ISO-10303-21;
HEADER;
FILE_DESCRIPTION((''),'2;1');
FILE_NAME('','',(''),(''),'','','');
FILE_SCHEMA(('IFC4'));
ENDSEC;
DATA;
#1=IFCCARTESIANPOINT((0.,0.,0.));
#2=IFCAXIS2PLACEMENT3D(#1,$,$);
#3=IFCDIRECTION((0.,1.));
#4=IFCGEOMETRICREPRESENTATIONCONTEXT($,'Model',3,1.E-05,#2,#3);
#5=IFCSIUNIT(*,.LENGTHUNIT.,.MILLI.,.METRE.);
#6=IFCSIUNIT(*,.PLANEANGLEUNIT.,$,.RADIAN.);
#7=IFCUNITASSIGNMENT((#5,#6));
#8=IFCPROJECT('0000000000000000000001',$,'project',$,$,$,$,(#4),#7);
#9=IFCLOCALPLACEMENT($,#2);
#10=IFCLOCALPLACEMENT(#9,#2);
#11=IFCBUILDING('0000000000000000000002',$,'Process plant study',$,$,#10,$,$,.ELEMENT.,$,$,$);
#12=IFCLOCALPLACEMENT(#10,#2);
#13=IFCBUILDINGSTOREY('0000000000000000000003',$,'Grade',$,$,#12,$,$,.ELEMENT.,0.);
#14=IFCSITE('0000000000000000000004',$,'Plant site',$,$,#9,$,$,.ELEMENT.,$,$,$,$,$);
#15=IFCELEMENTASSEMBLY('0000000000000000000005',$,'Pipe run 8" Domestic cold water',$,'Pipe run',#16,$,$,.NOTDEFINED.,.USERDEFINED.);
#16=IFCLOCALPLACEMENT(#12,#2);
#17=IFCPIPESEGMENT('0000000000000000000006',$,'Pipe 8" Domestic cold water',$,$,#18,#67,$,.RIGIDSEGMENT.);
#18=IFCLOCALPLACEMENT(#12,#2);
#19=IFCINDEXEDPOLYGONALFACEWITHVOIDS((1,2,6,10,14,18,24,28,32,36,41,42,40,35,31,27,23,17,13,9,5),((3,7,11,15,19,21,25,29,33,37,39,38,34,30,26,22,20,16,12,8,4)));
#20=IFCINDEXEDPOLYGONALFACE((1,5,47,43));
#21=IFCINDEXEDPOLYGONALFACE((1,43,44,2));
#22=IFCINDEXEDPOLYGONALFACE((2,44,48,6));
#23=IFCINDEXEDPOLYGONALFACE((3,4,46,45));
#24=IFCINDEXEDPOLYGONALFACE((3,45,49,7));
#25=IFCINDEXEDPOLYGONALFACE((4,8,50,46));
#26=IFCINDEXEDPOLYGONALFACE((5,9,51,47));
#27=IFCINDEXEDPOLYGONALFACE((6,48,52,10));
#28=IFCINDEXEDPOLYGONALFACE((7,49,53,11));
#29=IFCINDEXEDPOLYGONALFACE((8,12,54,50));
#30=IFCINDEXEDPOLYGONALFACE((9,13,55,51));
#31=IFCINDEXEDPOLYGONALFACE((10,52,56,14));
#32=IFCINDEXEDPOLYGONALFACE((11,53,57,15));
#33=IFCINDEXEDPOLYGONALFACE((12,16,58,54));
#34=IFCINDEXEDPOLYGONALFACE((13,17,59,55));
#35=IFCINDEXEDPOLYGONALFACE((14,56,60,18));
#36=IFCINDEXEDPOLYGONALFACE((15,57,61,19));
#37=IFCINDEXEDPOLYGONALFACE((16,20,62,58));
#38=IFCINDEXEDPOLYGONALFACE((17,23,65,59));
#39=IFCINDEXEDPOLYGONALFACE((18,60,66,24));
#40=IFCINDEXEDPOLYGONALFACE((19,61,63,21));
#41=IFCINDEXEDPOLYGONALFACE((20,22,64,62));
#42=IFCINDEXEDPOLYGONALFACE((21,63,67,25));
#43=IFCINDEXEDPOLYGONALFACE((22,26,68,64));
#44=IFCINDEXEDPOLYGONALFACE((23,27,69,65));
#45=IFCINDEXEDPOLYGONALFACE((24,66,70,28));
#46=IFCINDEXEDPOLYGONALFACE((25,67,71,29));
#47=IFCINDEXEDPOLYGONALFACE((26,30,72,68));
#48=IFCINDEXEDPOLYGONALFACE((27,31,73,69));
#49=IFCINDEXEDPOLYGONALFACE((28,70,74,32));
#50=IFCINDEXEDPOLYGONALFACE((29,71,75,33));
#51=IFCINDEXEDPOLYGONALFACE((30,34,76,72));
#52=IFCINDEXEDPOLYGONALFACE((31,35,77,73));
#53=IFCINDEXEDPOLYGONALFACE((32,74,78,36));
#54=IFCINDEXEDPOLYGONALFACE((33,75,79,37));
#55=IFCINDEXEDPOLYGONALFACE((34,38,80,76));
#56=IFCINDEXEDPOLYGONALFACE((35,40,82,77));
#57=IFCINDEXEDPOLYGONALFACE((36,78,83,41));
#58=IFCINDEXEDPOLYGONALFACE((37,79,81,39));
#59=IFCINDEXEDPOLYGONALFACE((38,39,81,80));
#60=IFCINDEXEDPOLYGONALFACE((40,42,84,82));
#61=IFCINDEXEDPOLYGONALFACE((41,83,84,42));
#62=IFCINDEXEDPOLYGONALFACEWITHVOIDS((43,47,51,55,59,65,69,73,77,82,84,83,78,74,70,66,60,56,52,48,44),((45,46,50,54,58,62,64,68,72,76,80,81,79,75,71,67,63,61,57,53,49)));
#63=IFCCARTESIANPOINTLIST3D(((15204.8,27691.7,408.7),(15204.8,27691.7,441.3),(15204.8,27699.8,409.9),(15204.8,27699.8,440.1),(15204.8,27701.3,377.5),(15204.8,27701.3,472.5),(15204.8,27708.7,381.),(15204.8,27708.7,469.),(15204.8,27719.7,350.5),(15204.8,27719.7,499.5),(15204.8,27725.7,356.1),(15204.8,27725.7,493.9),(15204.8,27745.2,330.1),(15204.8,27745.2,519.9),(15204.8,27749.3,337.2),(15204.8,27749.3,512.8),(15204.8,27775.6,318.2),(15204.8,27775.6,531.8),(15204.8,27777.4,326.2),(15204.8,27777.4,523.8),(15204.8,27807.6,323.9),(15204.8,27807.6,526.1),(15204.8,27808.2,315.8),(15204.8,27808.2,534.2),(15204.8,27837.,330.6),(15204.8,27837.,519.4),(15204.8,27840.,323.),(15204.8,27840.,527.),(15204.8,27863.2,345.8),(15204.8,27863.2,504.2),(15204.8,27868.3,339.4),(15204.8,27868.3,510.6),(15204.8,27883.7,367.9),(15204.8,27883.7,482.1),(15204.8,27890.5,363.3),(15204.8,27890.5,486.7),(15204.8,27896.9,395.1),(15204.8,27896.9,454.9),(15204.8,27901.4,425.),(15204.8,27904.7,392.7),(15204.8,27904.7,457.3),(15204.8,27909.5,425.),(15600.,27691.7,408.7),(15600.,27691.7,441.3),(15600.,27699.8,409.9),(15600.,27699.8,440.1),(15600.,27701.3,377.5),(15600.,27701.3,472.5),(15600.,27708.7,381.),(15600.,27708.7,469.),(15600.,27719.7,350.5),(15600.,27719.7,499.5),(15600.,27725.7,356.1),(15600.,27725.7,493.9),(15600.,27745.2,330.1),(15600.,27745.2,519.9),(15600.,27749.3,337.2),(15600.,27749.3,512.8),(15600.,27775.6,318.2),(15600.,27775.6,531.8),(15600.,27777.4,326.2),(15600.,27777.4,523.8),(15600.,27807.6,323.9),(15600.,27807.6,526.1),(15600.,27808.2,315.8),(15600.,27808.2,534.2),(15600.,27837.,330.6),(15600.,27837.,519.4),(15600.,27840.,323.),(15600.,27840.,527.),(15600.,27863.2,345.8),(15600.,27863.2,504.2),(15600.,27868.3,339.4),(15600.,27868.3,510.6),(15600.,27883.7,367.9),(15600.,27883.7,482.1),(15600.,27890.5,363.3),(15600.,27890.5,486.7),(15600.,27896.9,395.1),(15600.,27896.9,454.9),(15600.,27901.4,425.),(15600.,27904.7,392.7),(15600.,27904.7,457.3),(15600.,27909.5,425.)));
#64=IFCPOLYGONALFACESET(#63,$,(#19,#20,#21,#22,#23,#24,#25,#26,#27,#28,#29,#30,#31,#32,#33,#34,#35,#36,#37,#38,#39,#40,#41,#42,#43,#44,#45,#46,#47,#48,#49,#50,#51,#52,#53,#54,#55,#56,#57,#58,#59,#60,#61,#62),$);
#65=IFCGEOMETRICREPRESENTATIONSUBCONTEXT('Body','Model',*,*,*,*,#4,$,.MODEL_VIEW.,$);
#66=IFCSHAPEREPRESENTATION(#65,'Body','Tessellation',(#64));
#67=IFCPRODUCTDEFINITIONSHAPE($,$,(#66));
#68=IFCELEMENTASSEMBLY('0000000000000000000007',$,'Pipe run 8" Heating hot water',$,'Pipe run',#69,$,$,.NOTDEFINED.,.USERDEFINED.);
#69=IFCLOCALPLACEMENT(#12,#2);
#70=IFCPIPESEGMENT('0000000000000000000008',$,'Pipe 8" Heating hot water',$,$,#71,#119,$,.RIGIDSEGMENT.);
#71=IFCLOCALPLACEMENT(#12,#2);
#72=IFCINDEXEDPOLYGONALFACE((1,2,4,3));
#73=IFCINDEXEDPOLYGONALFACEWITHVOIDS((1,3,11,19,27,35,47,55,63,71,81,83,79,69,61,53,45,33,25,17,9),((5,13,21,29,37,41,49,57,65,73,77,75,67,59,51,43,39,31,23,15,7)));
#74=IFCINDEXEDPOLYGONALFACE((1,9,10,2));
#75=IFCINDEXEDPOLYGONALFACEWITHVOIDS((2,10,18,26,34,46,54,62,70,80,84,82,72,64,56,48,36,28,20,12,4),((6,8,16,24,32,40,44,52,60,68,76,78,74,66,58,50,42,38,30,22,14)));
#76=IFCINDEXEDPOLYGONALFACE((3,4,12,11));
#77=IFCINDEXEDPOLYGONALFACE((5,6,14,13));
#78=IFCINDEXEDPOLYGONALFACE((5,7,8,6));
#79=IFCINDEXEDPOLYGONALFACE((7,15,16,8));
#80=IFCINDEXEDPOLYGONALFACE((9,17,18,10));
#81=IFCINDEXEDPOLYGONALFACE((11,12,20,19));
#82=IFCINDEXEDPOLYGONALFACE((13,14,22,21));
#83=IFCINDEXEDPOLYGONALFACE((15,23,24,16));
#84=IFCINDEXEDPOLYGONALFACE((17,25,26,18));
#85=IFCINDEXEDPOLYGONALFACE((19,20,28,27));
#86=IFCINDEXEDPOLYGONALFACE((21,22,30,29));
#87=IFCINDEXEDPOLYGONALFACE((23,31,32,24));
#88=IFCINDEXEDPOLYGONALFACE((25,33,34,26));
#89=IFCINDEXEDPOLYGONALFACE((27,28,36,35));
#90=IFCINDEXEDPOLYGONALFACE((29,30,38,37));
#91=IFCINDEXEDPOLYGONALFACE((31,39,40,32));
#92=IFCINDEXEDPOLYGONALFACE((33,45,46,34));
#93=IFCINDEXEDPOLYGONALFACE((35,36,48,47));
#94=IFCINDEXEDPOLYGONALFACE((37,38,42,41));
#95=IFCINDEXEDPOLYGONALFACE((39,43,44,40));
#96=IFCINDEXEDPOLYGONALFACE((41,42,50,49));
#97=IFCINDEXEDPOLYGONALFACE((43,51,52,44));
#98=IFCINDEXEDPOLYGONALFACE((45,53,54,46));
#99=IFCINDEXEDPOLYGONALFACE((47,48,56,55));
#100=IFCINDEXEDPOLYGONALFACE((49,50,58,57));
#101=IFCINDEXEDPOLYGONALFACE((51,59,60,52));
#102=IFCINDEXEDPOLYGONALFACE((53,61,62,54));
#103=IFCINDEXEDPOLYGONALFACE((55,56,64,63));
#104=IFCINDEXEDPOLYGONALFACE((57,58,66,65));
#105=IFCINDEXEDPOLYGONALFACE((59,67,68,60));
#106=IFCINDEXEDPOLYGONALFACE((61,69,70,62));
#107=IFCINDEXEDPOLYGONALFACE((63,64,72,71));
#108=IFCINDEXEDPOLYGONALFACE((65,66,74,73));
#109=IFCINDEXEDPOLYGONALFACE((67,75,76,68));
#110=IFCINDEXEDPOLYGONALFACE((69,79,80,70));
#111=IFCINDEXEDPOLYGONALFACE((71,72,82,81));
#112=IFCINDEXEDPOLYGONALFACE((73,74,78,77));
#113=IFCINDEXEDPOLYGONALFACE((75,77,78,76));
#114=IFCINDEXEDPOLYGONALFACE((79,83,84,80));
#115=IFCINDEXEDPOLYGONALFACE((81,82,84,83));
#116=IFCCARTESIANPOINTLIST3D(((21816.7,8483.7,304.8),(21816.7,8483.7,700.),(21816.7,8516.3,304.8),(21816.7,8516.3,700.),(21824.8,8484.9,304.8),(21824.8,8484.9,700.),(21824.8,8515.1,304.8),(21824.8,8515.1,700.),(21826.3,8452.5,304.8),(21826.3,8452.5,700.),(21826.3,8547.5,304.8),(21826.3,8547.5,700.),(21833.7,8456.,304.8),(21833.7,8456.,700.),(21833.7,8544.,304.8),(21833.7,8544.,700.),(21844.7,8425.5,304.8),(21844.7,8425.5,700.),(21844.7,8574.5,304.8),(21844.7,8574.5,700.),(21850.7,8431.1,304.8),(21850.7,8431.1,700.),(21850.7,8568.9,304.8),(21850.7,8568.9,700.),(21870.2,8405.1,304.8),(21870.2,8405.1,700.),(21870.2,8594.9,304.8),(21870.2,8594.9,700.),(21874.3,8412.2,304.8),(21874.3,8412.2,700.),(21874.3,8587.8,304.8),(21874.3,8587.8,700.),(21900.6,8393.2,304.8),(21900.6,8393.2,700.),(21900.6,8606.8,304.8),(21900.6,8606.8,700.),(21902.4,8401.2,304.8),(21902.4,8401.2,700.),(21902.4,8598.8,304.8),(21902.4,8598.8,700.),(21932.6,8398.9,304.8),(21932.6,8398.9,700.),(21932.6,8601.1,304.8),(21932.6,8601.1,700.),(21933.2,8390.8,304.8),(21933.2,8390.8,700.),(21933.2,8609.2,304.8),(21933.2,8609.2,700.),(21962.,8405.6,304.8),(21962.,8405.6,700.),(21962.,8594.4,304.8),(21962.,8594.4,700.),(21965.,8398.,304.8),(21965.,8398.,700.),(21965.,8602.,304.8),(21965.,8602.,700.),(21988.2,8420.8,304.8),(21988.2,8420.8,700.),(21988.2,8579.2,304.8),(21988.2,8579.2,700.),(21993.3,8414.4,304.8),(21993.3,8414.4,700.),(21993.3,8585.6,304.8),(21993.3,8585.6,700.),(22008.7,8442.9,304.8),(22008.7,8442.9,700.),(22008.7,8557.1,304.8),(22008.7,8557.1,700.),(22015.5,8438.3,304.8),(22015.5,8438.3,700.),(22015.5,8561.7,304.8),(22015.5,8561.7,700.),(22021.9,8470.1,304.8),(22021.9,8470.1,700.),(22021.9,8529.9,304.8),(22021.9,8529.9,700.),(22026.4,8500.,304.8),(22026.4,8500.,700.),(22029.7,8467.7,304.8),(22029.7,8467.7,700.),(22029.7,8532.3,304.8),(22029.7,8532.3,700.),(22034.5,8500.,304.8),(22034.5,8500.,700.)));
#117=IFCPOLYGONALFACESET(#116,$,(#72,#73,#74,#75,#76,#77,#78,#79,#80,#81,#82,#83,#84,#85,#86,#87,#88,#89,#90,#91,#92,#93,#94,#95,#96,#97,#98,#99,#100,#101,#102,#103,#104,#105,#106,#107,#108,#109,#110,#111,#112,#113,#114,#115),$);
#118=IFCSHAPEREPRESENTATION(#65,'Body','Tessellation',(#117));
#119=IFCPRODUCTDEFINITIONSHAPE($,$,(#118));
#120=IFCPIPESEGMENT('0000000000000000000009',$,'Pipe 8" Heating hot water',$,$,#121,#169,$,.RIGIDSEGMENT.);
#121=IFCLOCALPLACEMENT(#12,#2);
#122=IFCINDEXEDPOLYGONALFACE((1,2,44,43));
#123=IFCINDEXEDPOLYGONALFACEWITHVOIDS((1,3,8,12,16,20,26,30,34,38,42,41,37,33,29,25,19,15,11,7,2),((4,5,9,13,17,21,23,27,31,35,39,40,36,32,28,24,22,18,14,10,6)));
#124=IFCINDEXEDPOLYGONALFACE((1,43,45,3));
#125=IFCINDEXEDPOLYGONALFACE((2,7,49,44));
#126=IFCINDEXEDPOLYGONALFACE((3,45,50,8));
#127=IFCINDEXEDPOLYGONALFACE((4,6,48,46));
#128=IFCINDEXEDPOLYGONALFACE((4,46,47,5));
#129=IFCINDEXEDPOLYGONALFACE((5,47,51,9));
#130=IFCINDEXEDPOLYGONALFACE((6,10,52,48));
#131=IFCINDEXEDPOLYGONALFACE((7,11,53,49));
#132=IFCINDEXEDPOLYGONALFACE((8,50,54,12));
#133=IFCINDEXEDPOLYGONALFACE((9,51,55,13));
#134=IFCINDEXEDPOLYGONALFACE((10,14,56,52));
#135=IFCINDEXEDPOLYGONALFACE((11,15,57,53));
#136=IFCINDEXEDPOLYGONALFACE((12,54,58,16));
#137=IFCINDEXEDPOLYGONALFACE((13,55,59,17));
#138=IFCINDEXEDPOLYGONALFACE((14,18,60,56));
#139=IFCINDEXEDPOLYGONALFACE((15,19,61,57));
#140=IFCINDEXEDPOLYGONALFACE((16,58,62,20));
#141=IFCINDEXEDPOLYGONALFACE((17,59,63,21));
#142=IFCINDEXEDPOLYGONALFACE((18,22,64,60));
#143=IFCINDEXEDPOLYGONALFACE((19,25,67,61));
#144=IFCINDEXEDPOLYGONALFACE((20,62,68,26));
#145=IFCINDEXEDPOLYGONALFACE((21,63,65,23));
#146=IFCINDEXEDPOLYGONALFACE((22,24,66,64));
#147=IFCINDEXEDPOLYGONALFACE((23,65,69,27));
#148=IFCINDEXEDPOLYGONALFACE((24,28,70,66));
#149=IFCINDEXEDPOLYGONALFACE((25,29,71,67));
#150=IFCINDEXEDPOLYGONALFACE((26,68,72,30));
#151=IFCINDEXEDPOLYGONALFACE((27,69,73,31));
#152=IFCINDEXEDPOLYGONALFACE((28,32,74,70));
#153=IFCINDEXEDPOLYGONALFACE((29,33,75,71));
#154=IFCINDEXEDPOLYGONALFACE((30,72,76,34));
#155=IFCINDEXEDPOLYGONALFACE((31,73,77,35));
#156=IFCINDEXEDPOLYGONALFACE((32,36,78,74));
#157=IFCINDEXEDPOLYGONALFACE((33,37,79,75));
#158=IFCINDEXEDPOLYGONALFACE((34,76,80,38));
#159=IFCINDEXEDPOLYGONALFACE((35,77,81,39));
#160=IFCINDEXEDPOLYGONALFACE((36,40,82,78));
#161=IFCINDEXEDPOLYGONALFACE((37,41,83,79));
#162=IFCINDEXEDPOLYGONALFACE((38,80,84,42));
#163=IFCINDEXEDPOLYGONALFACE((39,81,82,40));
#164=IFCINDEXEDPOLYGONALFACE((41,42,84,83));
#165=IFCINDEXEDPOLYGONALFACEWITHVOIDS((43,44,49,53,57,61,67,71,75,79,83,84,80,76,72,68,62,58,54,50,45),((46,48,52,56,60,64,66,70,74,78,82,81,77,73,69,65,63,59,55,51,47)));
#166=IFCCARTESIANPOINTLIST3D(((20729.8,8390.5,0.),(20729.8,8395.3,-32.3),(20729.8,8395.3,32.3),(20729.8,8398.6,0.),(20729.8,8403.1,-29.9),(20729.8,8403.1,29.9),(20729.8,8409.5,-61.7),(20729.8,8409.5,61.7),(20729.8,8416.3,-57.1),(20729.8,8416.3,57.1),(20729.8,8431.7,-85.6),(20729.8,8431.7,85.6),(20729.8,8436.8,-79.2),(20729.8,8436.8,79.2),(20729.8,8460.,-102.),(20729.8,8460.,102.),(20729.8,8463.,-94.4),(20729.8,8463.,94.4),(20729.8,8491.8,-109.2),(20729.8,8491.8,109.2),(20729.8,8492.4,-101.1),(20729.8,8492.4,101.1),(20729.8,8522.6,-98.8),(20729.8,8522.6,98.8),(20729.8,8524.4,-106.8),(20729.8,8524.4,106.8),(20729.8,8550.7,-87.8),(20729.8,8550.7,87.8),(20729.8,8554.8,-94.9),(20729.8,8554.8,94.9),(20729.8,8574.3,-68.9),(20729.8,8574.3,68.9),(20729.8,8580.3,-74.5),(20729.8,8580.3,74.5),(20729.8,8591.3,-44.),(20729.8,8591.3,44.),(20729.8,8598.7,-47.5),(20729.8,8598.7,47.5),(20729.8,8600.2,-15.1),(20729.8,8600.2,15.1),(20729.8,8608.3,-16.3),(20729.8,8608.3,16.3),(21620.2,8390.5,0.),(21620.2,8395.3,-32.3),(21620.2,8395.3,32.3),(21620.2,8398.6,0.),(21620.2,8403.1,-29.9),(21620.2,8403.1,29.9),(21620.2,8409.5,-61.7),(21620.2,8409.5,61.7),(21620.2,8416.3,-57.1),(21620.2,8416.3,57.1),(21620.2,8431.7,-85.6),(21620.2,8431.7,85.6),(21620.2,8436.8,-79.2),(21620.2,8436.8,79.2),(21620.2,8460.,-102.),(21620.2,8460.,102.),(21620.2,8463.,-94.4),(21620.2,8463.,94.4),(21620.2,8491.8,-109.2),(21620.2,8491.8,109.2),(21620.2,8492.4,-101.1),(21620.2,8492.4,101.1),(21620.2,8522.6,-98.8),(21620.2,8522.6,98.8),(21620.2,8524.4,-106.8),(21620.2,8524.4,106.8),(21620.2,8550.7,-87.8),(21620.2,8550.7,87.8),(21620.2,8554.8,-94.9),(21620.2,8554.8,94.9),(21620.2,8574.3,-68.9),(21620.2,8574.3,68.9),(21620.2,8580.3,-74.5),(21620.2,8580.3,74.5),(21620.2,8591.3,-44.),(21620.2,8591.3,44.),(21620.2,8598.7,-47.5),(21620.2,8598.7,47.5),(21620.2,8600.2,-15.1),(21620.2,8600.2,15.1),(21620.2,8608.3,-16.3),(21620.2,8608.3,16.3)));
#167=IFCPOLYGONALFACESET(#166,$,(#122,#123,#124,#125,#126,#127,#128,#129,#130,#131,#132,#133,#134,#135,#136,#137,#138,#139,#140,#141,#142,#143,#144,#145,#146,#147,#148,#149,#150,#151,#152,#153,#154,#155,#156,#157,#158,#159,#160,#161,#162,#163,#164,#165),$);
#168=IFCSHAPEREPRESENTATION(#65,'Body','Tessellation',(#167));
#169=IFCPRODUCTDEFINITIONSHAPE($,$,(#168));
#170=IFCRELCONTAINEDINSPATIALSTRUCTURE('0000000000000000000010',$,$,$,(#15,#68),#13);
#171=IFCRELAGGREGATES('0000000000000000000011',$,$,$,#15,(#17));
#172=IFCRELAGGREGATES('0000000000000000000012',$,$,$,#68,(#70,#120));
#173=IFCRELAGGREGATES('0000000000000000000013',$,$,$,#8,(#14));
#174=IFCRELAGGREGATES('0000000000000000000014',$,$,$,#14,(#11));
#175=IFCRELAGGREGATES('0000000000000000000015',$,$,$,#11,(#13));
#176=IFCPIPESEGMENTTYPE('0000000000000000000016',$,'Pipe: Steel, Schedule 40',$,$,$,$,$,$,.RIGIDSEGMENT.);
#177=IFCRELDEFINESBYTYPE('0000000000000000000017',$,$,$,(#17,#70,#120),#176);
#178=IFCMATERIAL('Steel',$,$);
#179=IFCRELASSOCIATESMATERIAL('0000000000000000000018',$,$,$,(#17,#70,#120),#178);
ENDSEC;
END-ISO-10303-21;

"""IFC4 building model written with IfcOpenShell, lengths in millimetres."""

from ifc_helpers import new_model, si_unit, direction, frame, origin, origin_with_axes, origin_2d, place, context, subcontext, project, spatial, hollow_circle, extrude, material, type_object, element, aggregate, save


model = new_model("IFC4")

# Units and contexts
model_context = context("Model", 3, precision=1e-05, world=origin(), true_north=direction((0.0, 1.0)))
body_context = subcontext(model_context, "Body", "Model", "MODEL_VIEW")
ifc_project = project(units=[si_unit("LENGTHUNIT", "METRE", prefix="MILLI"), si_unit("PLANEANGLEUNIT", "RADIAN")], contexts=[model_context])

# Site, building, storey
site_placement = place(None, origin())
site = spatial("IfcSite", under=ifc_project, at=site_placement, Name="Plant site", CompositionType="ELEMENT")
building_placement = place(site_placement, origin())
building = spatial("IfcBuilding", under=site, at=building_placement, Name="Process plant study", CompositionType="ELEMENT")
storey_placement = place(building_placement, origin())
storey = spatial("IfcBuildingStorey", under=building, at=storey_placement, Name="Grade", CompositionType="ELEMENT", Elevation=0.0)

# Element assemblies, pipe segments
assembly_1_placement = place(storey_placement, origin_with_axes())
assembly_1 = element("IfcElementAssembly", 1, at=assembly_1_placement, inside=storey, Name="Pipe run 8\" Domestic cold water", ObjectType="Pipe run", AssemblyPlace="NOTDEFINED", PredefinedType="USERDEFINED")
ifc_material = material(Name="Steel")
pipe_segment_type = type_object("IfcPipeSegmentType", Name="Pipe: Steel, Schedule 40", PredefinedType="RIGIDSEGMENT")
pipe_segment_1_placement = place(storey_placement, origin_with_axes())
pipe_segment_1 = element("IfcPipeSegment", 2, at=pipe_segment_1_placement, type_object=pipe_segment_type, material=ifc_material, Name="Pipe 8\" Domestic cold water", PredefinedType="RIGIDSEGMENT", context=body_context, shape_type="SweptSolid", body=[
    extrude(hollow_circle(Radius=109.5, WallThickness=8.2, at=origin_2d()), frame((15204.8, 27800.0, 425.0), z_axis=(1.0, 0.0, 0.0), x_axis=(0.0, 1.0, 0.0)), (0.0, 0.0, 1.0), 395.2),
])
assembly_2_placement = place(storey_placement, origin_with_axes())
assembly_2 = element("IfcElementAssembly", 3, at=assembly_2_placement, inside=storey, Name="Pipe run 8\" Heating hot water", ObjectType="Pipe run", AssemblyPlace="NOTDEFINED", PredefinedType="USERDEFINED")
pipe_segment_2_placement = place(storey_placement, origin_with_axes())
pipe_segment_2 = element("IfcPipeSegment", 4, at=pipe_segment_2_placement, type_object=pipe_segment_type, material=ifc_material, Name="Pipe 8\" Heating hot water", PredefinedType="RIGIDSEGMENT", context=body_context, shape_type="SweptSolid", body=[
    extrude(hollow_circle(Radius=109.5, WallThickness=8.2, at=origin_2d()), frame((21925.0, 8500.0, 700.0), z_axis=(0.0, 0.0, -1.0), x_axis=(1.0, 0.0, 0.0)), (0.0, 0.0, 1.0), 395.2),
])
pipe_segment_3_placement = place(storey_placement, origin_with_axes())
pipe_segment_3 = element("IfcPipeSegment", 5, at=pipe_segment_3_placement, type_object=pipe_segment_type, material=ifc_material, Name="Pipe 8\" Heating hot water", PredefinedType="RIGIDSEGMENT", context=body_context, shape_type="SweptSolid", body=[
    extrude(hollow_circle(Radius=109.5, WallThickness=8.2, at=origin_2d()), frame((21620.2, 8500.0, 0.0), z_axis=(-1.0, 0.0, 0.0), x_axis=(0.0, -1.0, 0.0)), (0.0, 0.0, 1.0), 890.4),
])

aggregate(assembly_1, [pipe_segment_1])
aggregate(assembly_2, [pipe_segment_2, pipe_segment_3])

save(model, "model.ifc")
